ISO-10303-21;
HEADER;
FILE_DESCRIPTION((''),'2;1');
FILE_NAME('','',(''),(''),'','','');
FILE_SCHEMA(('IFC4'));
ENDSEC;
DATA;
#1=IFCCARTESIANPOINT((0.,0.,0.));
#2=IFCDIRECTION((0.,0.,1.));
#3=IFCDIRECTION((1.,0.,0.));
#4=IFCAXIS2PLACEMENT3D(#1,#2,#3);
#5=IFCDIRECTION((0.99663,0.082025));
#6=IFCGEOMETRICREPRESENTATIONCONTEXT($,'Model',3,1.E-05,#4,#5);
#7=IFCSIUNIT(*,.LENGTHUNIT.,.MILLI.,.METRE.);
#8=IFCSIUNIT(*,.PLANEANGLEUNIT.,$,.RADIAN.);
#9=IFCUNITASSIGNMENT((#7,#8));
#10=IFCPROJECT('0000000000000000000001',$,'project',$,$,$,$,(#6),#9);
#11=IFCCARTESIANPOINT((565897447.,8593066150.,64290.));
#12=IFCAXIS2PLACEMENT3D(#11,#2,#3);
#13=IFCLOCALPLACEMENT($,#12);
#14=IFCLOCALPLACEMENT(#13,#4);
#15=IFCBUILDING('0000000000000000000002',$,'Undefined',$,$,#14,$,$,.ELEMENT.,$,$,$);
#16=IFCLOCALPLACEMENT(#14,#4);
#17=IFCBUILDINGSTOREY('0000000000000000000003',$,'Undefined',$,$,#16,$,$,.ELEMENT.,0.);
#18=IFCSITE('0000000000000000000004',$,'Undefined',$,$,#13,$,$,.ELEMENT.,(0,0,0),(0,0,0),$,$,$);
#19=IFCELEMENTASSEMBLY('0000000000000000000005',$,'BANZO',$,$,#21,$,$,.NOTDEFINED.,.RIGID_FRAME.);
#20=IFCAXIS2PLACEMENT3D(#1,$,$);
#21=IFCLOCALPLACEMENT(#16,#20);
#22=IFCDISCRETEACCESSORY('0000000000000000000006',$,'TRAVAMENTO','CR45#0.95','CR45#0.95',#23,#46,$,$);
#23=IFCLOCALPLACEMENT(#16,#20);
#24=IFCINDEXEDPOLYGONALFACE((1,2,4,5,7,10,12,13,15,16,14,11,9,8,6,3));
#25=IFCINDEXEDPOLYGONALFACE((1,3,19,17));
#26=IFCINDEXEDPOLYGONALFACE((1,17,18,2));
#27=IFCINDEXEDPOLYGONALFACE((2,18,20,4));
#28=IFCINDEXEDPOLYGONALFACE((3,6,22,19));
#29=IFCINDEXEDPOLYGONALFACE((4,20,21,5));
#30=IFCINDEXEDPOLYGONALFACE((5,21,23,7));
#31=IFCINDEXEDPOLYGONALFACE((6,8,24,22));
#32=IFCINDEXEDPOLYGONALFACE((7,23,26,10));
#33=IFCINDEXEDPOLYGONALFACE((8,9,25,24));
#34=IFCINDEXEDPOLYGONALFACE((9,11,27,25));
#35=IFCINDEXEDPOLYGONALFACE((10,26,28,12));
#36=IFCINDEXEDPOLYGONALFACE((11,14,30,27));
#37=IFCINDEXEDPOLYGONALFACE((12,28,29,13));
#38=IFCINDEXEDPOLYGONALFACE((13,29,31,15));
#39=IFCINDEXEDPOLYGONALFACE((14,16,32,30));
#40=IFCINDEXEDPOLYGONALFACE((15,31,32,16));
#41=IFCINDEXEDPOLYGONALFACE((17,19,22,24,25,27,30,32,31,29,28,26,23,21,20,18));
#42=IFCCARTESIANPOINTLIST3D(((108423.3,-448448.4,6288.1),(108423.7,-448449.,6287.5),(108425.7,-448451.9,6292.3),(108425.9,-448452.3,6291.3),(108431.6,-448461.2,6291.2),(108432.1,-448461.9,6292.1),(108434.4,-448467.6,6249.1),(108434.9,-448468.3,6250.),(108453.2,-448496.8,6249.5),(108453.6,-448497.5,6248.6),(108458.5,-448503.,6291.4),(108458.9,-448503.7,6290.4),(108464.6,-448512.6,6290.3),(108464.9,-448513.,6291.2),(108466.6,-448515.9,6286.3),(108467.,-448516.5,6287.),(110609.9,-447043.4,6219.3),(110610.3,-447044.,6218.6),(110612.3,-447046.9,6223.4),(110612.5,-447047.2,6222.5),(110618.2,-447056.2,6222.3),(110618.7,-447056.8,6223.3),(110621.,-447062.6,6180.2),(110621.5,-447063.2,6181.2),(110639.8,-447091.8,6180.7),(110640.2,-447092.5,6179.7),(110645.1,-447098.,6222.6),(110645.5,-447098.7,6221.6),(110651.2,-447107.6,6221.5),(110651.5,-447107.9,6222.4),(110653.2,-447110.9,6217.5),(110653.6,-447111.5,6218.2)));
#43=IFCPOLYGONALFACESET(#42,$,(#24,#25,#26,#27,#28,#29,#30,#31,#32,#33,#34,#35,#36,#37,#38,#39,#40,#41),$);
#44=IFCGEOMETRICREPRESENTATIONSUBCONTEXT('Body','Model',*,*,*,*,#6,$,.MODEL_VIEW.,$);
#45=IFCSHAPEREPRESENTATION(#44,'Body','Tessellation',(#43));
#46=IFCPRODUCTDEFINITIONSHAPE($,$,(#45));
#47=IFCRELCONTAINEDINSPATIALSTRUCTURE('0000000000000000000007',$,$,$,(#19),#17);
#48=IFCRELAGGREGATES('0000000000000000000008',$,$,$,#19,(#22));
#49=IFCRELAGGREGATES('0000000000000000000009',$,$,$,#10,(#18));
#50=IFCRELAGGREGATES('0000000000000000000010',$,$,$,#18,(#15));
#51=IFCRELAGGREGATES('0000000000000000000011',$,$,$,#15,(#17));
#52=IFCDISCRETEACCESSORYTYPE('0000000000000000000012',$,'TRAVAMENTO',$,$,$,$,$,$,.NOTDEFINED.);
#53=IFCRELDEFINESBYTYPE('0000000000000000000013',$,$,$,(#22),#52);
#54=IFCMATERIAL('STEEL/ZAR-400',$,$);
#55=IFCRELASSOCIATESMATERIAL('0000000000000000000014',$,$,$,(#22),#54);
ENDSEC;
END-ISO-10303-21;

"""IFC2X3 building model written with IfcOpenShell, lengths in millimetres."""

from ifc_helpers import new_model, si_unit, direction, frame, origin_with_axes, place, context, subcontext, project, spatial, polyline, outline, extrude, material, type_object, element, aggregate, save


model = new_model("IFC2X3")

# Units and contexts
model_context = context("Model", 3, precision=1e-05, world=origin_with_axes(), true_north=direction((0.99663, 0.082025)))
body_context = subcontext(model_context, "Body", "Model", "MODEL_VIEW")
ifc_project = project(units=[si_unit("LENGTHUNIT", "METRE", prefix="MILLI"), si_unit("PLANEANGLEUNIT", "RADIAN")], contexts=[model_context])

# Site, building, storey
site_placement = place(None, frame((565897447.0, 8593066150.0, 64290.0), z_axis=(0.0, 0.0, 1.0), x_axis=(1.0, 0.0, 0.0)))
site = spatial("IfcSite", under=ifc_project, at=site_placement, Name="Undefined", CompositionType="ELEMENT", RefLatitude=(0, 0, 0), RefLongitude=(0, 0, 0))
building_placement = place(site_placement, origin_with_axes())
building = spatial("IfcBuilding", under=site, at=building_placement, Name="Undefined", CompositionType="ELEMENT")
storey_placement = place(building_placement, origin_with_axes())
storey = spatial("IfcBuildingStorey", under=building, at=storey_placement, Name="Undefined", CompositionType="ELEMENT", Elevation=0.0)

# Shared definitions
ifc_material_1 = material(Name="STEEL/ZAR-400")

# Element assembly
assembly_1_placement = place(storey_placement, origin_with_axes())
assembly_1 = element("IfcElementAssembly", 1, at=assembly_1_placement, inside=storey, Name="BANZO", AssemblyPlace="NOTDEFINED", PredefinedType="RIGID_FRAME")

# Discrete accessory
discrete_accessory_type_1 = type_object("IfcDiscreteAccessoryType", Name="TRAVAMENTO")
discrete_accessory_1_placement = place(assembly_1_placement, frame((108444.8, -448482.8, 6270.3), z_axis=(-0.029884, -0.002459, -0.99955), x_axis=(0.840995, 0.540395, -0.026473)))
discrete_accessory_1 = element("IfcDiscreteAccessory", 2, at=discrete_accessory_1_placement, type_object=discrete_accessory_type_1, material=ifc_material_1, Name="TRAVAMENTO", Description="CR45#0.95", ObjectType="CR45#0.95", context=body_context, shape_type="SweptSolid", body=[
    extrude(outline(polyline([(-35.5, -20.5), (-24.9, -20.5), (-17.4, 21.5), (18.1, 21.5), (25.6, -20.5), (36.2, -20.5), (40.1, -16.6), (40.8, -17.3), (36.6, -21.5), (24.8, -21.5), (17.3, 20.5), (-16.6, 20.5), (-24.1, -21.5), (-35.9, -21.5), (-40.1, -17.3), (-39.4, -16.6), (-35.5, -20.5)])), frame((2600.0, 0.0, 0.0), z_axis=(-1.0, 0.0, 0.0), x_axis=(0.0, -1.0, 0.0)), (0.0, 0.0, 1.0), 2600.0),
])
aggregate(assembly_1, [discrete_accessory_1])

save(model, "model.ifc")
